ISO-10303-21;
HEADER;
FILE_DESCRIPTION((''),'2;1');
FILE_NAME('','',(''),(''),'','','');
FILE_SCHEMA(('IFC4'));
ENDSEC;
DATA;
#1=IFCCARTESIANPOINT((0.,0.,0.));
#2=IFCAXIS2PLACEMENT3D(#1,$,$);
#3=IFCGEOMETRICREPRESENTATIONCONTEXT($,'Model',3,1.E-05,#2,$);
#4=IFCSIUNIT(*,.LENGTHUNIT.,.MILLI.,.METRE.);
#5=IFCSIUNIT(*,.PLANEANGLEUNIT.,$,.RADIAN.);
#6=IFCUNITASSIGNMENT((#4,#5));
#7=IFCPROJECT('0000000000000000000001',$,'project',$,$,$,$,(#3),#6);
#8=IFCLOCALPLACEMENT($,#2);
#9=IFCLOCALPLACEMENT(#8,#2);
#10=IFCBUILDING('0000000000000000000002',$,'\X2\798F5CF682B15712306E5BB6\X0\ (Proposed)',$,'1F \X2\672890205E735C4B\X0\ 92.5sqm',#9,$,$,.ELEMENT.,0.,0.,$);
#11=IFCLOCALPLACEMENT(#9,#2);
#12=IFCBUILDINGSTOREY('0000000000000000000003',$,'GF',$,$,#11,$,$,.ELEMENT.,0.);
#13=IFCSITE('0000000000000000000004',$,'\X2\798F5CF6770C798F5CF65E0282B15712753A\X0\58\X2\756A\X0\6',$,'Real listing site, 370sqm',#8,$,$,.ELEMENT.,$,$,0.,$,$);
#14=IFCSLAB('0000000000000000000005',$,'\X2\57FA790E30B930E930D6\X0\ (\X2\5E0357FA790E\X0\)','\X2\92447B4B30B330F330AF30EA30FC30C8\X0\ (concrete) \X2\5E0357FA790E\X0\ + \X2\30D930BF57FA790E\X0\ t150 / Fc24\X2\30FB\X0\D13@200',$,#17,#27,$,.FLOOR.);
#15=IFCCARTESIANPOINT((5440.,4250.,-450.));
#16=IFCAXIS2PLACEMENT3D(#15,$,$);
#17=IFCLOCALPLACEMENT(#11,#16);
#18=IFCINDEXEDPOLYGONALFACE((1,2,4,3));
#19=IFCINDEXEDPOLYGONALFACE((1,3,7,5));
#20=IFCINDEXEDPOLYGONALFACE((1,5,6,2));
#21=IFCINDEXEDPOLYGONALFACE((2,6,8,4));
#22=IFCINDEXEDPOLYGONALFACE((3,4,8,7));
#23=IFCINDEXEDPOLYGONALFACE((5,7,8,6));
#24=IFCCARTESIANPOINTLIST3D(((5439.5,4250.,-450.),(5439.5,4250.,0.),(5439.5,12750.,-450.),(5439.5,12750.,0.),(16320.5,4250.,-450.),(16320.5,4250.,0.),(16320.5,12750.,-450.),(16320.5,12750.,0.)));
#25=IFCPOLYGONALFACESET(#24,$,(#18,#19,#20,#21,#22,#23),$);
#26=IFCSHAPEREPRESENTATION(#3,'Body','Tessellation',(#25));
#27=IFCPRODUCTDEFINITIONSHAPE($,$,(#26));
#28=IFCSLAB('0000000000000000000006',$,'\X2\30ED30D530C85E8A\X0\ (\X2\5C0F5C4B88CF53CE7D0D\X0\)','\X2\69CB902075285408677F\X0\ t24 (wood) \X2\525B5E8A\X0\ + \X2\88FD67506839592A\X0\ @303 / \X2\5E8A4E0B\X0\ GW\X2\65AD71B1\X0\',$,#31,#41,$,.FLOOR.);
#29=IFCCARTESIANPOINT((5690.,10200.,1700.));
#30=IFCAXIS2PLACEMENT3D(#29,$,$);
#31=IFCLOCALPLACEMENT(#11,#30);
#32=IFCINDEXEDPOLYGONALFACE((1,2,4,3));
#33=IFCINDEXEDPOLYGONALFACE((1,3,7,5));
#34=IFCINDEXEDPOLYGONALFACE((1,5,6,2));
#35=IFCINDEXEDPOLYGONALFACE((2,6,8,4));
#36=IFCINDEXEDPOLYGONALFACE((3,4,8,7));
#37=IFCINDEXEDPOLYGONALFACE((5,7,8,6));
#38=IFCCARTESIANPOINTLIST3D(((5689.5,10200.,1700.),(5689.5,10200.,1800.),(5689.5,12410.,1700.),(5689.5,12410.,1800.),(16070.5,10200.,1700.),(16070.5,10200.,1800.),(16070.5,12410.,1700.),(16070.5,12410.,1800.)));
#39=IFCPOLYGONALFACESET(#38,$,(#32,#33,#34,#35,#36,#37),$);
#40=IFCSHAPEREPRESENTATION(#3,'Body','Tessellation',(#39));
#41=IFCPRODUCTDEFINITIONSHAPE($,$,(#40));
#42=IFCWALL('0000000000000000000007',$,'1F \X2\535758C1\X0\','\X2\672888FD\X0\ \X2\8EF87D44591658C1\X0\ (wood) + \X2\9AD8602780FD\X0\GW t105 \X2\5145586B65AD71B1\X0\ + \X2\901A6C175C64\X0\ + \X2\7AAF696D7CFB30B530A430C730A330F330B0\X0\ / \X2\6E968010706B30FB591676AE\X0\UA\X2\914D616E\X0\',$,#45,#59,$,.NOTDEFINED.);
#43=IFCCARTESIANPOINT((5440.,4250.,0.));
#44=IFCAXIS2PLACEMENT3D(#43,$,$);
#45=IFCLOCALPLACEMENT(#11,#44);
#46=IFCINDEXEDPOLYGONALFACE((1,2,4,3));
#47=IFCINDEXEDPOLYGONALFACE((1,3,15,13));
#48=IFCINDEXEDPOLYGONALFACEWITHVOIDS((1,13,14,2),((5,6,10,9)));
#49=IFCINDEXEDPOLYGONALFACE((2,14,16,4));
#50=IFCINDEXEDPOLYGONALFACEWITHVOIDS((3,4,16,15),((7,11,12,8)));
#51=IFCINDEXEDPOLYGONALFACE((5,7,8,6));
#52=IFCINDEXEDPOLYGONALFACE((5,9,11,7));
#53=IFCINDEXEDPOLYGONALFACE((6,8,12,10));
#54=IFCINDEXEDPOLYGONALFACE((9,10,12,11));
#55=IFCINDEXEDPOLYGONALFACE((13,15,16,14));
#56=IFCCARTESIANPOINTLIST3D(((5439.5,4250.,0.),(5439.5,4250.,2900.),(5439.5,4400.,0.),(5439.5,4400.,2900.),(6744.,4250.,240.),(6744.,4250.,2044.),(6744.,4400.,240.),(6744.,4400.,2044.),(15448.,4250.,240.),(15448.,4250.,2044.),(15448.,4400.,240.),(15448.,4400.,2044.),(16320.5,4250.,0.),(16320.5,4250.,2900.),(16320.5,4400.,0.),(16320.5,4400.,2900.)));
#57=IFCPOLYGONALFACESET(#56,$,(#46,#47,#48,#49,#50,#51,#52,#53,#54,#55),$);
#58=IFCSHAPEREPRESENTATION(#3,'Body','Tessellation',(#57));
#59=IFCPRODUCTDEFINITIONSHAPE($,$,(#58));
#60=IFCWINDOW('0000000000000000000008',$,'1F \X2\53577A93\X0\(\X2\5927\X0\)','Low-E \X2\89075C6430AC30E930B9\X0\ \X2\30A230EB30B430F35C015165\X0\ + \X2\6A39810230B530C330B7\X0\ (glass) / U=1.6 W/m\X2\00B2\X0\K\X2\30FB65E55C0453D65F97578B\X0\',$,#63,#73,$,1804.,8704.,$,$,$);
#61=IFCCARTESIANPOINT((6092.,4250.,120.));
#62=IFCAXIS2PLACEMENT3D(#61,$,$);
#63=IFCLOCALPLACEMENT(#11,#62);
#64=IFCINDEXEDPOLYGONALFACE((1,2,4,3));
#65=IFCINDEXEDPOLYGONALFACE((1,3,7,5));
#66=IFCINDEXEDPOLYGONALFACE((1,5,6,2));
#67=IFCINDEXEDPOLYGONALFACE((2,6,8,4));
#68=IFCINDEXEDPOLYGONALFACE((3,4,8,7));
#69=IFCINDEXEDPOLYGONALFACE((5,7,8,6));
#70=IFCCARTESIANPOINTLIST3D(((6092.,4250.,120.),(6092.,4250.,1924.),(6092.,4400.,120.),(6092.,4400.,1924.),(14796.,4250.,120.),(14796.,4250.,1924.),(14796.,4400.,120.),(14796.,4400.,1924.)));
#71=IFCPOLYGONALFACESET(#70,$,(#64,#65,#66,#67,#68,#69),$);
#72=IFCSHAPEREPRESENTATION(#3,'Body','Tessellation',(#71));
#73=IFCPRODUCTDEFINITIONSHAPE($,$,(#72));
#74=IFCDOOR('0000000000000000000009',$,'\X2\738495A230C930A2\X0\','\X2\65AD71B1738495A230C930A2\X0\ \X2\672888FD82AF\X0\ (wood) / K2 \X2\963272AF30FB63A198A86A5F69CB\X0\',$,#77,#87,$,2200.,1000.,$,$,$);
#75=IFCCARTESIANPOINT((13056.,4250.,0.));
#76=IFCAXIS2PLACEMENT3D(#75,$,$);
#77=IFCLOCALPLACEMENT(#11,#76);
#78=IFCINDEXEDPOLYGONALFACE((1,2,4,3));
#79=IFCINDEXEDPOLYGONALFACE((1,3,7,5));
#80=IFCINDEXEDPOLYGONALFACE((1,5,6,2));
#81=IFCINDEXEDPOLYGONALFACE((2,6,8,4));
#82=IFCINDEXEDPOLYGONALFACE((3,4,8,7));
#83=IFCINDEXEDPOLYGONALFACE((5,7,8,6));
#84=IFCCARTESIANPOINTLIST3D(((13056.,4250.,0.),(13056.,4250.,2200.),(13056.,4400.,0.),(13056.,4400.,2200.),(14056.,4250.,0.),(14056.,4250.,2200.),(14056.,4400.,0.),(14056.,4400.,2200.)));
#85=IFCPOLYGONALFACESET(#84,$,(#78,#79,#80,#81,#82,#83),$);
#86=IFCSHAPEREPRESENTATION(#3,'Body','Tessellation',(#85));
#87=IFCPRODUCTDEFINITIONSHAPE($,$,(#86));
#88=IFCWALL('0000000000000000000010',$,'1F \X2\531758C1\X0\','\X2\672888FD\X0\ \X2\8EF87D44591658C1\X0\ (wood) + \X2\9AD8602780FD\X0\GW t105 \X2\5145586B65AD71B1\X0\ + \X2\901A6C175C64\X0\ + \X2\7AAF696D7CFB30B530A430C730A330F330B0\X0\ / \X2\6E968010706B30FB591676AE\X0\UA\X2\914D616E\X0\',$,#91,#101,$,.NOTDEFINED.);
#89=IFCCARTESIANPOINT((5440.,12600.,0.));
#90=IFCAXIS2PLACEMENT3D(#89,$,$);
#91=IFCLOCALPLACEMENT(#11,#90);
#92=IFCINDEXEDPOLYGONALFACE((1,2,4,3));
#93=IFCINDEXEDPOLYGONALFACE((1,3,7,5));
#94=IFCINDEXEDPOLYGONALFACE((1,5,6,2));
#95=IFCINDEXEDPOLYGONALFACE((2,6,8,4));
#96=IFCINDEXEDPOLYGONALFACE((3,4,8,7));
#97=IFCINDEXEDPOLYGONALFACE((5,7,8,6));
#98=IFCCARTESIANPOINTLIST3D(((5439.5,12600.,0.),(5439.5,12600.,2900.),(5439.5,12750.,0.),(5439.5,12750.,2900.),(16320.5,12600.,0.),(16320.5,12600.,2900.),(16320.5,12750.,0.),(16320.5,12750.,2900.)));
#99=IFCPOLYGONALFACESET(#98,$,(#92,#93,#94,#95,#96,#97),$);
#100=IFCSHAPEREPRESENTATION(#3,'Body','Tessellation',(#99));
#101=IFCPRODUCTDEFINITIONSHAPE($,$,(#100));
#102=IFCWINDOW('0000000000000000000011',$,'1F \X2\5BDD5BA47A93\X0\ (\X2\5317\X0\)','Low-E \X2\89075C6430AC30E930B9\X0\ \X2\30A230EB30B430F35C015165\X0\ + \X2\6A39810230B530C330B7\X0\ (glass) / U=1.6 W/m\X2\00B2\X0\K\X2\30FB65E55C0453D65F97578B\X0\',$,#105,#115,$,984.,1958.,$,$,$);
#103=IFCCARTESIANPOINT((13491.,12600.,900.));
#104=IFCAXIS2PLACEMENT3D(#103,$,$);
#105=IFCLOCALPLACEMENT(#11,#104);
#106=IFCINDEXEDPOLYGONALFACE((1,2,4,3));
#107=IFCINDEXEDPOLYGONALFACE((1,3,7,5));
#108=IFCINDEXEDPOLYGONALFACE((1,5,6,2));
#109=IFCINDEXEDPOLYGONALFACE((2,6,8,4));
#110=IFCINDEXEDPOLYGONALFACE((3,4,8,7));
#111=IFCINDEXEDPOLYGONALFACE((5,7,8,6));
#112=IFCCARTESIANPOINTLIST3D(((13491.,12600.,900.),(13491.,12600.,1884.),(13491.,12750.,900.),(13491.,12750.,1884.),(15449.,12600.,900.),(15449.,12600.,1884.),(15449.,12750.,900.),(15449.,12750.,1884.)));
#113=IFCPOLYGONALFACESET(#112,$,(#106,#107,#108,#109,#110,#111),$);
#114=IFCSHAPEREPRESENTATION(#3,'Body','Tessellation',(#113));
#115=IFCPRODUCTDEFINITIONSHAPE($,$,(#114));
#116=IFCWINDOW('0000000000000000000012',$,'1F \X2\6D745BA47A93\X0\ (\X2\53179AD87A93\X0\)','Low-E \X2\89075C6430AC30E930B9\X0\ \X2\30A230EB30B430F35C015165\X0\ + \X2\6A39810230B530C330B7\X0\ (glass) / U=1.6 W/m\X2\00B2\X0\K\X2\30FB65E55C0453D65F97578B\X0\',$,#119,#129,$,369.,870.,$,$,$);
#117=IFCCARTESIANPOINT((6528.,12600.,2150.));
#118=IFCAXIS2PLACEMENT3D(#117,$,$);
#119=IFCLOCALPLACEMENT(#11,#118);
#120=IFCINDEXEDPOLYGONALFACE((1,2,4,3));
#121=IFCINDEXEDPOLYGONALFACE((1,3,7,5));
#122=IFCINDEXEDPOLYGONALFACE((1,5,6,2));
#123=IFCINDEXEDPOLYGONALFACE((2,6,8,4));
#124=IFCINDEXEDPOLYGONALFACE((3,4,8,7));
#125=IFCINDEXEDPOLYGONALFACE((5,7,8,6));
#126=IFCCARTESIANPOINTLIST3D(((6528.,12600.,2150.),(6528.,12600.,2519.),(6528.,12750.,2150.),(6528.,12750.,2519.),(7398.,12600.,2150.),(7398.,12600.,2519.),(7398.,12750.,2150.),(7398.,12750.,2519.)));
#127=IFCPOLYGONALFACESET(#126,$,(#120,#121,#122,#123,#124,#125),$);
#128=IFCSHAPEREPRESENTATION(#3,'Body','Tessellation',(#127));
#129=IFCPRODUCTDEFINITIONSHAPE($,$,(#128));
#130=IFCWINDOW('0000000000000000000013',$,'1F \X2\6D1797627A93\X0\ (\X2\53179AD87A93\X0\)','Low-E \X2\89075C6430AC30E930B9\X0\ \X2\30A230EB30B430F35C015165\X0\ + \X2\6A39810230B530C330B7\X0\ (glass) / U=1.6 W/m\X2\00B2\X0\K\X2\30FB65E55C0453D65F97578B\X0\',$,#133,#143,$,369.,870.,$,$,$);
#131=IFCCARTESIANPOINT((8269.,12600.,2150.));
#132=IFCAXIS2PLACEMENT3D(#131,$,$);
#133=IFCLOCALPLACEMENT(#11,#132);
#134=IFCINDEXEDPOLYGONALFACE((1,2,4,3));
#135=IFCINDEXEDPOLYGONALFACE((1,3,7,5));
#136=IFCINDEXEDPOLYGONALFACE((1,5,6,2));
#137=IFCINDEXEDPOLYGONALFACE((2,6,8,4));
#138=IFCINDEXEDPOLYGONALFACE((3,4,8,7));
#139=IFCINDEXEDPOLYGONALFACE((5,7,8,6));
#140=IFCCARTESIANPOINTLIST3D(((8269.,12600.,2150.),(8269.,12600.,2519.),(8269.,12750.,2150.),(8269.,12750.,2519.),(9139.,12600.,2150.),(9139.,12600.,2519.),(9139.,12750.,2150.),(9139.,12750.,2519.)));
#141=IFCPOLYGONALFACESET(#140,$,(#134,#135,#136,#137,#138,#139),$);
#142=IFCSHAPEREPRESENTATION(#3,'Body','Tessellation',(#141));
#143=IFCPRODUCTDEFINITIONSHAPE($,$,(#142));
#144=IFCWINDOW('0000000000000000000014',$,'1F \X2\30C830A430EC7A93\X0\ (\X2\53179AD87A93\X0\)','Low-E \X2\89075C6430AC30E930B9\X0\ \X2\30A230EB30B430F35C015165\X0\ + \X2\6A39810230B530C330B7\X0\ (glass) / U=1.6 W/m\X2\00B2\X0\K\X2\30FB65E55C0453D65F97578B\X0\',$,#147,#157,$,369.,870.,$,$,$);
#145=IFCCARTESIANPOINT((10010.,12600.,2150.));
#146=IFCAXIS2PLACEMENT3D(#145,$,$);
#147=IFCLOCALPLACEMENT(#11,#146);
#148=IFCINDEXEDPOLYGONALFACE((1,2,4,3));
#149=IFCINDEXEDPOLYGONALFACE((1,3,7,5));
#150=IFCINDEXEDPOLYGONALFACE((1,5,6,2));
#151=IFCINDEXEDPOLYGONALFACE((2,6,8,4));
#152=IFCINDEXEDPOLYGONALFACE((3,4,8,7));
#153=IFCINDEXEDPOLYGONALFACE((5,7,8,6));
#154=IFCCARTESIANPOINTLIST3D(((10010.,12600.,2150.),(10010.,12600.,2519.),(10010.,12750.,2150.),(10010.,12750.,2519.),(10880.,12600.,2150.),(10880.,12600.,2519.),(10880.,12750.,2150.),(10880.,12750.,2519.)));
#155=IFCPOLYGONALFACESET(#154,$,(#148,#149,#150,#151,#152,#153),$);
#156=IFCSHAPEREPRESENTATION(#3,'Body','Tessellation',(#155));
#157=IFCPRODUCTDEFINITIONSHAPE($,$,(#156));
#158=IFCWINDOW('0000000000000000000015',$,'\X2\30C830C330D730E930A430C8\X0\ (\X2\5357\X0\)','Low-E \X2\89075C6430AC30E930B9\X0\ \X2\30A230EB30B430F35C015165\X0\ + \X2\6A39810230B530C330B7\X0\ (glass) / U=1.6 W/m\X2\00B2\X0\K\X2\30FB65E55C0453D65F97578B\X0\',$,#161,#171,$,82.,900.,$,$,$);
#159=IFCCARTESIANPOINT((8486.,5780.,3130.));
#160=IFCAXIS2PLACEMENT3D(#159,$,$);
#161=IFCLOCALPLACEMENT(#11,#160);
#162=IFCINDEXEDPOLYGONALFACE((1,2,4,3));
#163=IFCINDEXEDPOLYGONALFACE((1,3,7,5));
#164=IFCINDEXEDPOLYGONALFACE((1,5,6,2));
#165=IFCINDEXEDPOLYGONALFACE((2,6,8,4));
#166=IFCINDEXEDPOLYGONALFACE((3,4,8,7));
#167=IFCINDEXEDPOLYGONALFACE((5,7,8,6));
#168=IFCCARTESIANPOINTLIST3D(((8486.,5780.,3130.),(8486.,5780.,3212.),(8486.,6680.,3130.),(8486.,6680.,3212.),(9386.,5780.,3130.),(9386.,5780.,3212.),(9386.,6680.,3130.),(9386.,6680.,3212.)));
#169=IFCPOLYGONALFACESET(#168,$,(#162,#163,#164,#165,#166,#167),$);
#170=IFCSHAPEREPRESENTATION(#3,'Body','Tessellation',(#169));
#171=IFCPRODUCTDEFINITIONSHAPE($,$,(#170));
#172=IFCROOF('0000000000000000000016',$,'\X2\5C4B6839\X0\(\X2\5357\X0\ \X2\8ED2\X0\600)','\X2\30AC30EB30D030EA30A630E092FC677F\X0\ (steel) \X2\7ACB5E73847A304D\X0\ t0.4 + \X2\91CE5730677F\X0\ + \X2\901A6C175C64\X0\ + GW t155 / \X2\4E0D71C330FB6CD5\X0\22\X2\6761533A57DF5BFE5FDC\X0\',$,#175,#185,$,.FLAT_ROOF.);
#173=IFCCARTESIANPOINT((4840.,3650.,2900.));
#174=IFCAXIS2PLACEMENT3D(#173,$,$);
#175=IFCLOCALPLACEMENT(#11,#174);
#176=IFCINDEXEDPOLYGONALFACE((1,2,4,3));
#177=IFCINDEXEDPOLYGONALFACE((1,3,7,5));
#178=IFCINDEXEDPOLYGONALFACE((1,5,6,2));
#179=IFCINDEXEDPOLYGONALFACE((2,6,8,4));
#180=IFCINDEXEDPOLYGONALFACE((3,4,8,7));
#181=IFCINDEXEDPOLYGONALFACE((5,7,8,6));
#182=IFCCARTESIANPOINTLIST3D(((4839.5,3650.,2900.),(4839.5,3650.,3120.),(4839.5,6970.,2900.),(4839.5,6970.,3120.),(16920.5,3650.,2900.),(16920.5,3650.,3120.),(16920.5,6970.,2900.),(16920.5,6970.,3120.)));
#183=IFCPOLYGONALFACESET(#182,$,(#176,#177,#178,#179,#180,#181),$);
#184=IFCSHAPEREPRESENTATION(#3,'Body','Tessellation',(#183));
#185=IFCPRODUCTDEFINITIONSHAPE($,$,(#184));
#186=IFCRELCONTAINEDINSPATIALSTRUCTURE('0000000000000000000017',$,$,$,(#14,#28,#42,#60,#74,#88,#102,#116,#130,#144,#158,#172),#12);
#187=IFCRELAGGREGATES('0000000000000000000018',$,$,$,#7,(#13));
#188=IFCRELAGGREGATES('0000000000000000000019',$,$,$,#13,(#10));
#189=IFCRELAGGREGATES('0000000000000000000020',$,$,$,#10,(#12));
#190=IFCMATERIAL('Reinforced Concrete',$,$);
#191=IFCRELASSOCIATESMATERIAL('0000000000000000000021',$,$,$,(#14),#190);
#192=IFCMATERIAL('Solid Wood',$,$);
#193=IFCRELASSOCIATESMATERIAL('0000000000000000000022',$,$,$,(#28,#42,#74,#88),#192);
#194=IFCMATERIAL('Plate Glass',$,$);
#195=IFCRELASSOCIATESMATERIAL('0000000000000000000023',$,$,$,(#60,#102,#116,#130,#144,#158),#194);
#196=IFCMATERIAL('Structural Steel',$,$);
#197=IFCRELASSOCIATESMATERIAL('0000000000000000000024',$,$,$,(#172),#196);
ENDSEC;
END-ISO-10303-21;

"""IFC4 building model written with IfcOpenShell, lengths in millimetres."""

from ifc_helpers import new_model, si_unit, frame, frame_2d, origin, place, context, project, spatial, rectangle, extrude, material, element, fill, save


model = new_model("IFC4")

# Units and contexts
model_context = context("Model", 3, precision=1e-05, world=origin())
ifc_project = project(units=[si_unit("LENGTHUNIT", "METRE", prefix="MILLI"), si_unit("PLANEANGLEUNIT", "RADIAN")], contexts=[model_context])

# Site, building, storey
site_placement = place(None, origin())
site = spatial("IfcSite", under=ifc_project, at=site_placement, Name="福島県福島市花園町58番6", ObjectType="Real listing site, 370sqm", CompositionType="ELEMENT", RefElevation=0.0)
building_placement = place(site_placement, origin())
building = spatial("IfcBuilding", under=site, at=building_placement, Name="福島花園の家 (Proposed)", ObjectType="1F 木造平屋 92.5sqm", CompositionType="ELEMENT", ElevationOfRefHeight=0.0, ElevationOfTerrain=0.0)
storey_placement = place(building_placement, origin())
storey = spatial("IfcBuildingStorey", under=building, at=storey_placement, Name="GF", CompositionType="ELEMENT", Elevation=0.0)

# Slabs
ifc_material_1 = material(Name="Reinforced Concrete")
slab_1_placement = place(storey_placement, frame((5440.0, 4250.0, -450.0)))
element("IfcSlab", 1, at=slab_1_placement, inside=storey, material=ifc_material_1, Name="基礎スラブ (布基礎)", Description="鉄筋コンクリート (concrete) 布基礎 + ベタ基礎 t150 / Fc24・D13@200", PredefinedType="FLOOR", context=model_context, shape_type="SweptSolid", body=[
    extrude(rectangle(XDim=10881.0, YDim=8500.0, at=frame_2d((5440.0, 4250.0))), frame((5440.0, 4250.0, -450.0)), (0.0, 0.0, 1.0), 450.0),
])
ifc_material_2 = material(Name="Solid Wood")
slab_2_placement = place(storey_placement, frame((5690.0, 10200.0, 1700.0)))
element("IfcSlab", 2, at=slab_2_placement, inside=storey, material=ifc_material_2, Name="ロフト床 (小屋裏収納)", Description="構造用合板 t24 (wood) 剛床 + 製材根太 @303 / 床下 GW断熱", PredefinedType="FLOOR", context=model_context, shape_type="SweptSolid", body=[
    extrude(rectangle(XDim=10381.0, YDim=2210.0, at=frame_2d((5190.0, 1105.0))), frame((5690.0, 10200.0, 1700.0)), (0.0, 0.0, 1.0), 100.0),
])

# Wall, openings, window, door
wall_1_placement = place(storey_placement, frame((5440.0, 4250.0, 0.0)))
wall_1 = element("IfcWall", 3, at=wall_1_placement, inside=storey, material=ifc_material_2, Name="1F 南壁", Description="木製 軸組外壁 (wood) + 高性能GW t105 充填断熱 + 通気層 + 窯業系サイディング / 準耐火・外皮UA配慮", PredefinedType="NOTDEFINED", context=model_context, shape_type="SweptSolid", body=[
    extrude(rectangle(XDim=10881.0, YDim=150.0, at=frame_2d((5440.0, 75.0))), frame((5440.0, 4250.0, 0.0)), (0.0, 0.0, 1.0), 2900.0),
])
opening_1_placement = place(storey_placement, frame((6092.0, 4250.0, 120.0)))
opening_1 = element("IfcOpeningElement", 4, at=opening_1_placement, cuts=wall_1, PredefinedType="NOTDEFINED", context=model_context, shape_type="SweptSolid", body=[
    extrude(rectangle(XDim=8704.0, YDim=150.0, at=frame_2d((4352.0, 75.0))), frame((6092.0, 4250.0, 120.0)), (0.0, 0.0, 1.0), 1804.0),
])
opening_2_placement = place(storey_placement, frame((13056.0, 4250.0, 0.0)))
opening_2 = element("IfcOpeningElement", 5, at=opening_2_placement, cuts=wall_1, PredefinedType="NOTDEFINED", context=model_context, shape_type="SweptSolid", body=[
    extrude(rectangle(XDim=1000.0, YDim=150.0, at=frame_2d((500.0, 75.0))), frame((13056.0, 4250.0, 0.0)), (0.0, 0.0, 1.0), 2200.0),
])
ifc_material_3 = material(Name="Plate Glass")
window_1_placement = place(storey_placement, frame((6092.0, 4250.0, 120.0)))
window_1 = element("IfcWindow", 6, at=window_1_placement, inside=storey, material=ifc_material_3, Name="1F 南窓(大)", Description="Low-E 複層ガラス アルゴン封入 + 樹脂サッシ (glass) / U=1.6 W/m²K・日射取得型", OverallHeight=1804.0, OverallWidth=8704.0, context=model_context, shape_type="SweptSolid", body=[
    extrude(rectangle(XDim=8704.0, YDim=150.0, at=frame_2d((4352.0, 75.0))), frame((6092.0, 4250.0, 120.0)), (0.0, 0.0, 1.0), 1804.0),
])
fill(opening_1, window_1)
door_1_placement = place(storey_placement, frame((13056.0, 4250.0, 0.0)))
door_1 = element("IfcDoor", 7, at=door_1_placement, inside=storey, material=ifc_material_2, Name="玄関ドア", Description="断熱玄関ドア 木製芯 (wood) / K2 防犯・採風機構", OverallHeight=2200.0, OverallWidth=1000.0, context=model_context, shape_type="SweptSolid", body=[
    extrude(rectangle(XDim=1000.0, YDim=150.0, at=frame_2d((500.0, 75.0))), frame((13056.0, 4250.0, 0.0)), (0.0, 0.0, 1.0), 2200.0),
])
fill(opening_2, door_1)

# Wall, openings, windows
wall_2_placement = place(storey_placement, frame((5440.0, 12600.0, 0.0)))
wall_2 = element("IfcWall", 8, at=wall_2_placement, inside=storey, material=ifc_material_2, Name="1F 北壁", Description="木製 軸組外壁 (wood) + 高性能GW t105 充填断熱 + 通気層 + 窯業系サイディング / 準耐火・外皮UA配慮", PredefinedType="NOTDEFINED", context=model_context, shape_type="SweptSolid", body=[
    extrude(rectangle(XDim=10881.0, YDim=150.0, at=frame_2d((5440.0, 75.0))), frame((5440.0, 12600.0, 0.0)), (0.0, 0.0, 1.0), 2900.0),
])
opening_3_placement = place(storey_placement, frame((13491.0, 12600.0, 900.0)))
opening_3 = element("IfcOpeningElement", 9, at=opening_3_placement, cuts=wall_2, PredefinedType="NOTDEFINED", context=model_context, shape_type="SweptSolid", body=[
    extrude(rectangle(XDim=1958.0, YDim=150.0, at=frame_2d((979.0, 75.0))), frame((13491.0, 12600.0, 900.0)), (0.0, 0.0, 1.0), 984.0),
])
opening_4_placement = place(storey_placement, frame((6528.0, 12600.0, 2150.0)))
opening_4 = element("IfcOpeningElement", 10, at=opening_4_placement, cuts=wall_2, PredefinedType="NOTDEFINED", context=model_context, shape_type="SweptSolid", body=[
    extrude(rectangle(XDim=870.0, YDim=150.0, at=frame_2d((435.0, 75.0))), frame((6528.0, 12600.0, 2150.0)), (0.0, 0.0, 1.0), 369.0),
])
opening_5_placement = place(storey_placement, frame((8269.0, 12600.0, 2150.0)))
opening_5 = element("IfcOpeningElement", 11, at=opening_5_placement, cuts=wall_2, PredefinedType="NOTDEFINED", context=model_context, shape_type="SweptSolid", body=[
    extrude(rectangle(XDim=870.0, YDim=150.0, at=frame_2d((435.0, 75.0))), frame((8269.0, 12600.0, 2150.0)), (0.0, 0.0, 1.0), 369.0),
])
opening_6_placement = place(storey_placement, frame((10010.0, 12600.0, 2150.0)))
opening_6 = element("IfcOpeningElement", 12, at=opening_6_placement, cuts=wall_2, PredefinedType="NOTDEFINED", context=model_context, shape_type="SweptSolid", body=[
    extrude(rectangle(XDim=870.0, YDim=150.0, at=frame_2d((435.0, 75.0))), frame((10010.0, 12600.0, 2150.0)), (0.0, 0.0, 1.0), 369.0),
])
window_2_placement = place(storey_placement, frame((13491.0, 12600.0, 900.0)))
window_2 = element("IfcWindow", 13, at=window_2_placement, inside=storey, material=ifc_material_3, Name="1F 寝室窓 (北)", Description="Low-E 複層ガラス アルゴン封入 + 樹脂サッシ (glass) / U=1.6 W/m²K・日射取得型", OverallHeight=984.0, OverallWidth=1958.0, context=model_context, shape_type="SweptSolid", body=[
    extrude(rectangle(XDim=1958.0, YDim=150.0, at=frame_2d((979.0, 75.0))), frame((13491.0, 12600.0, 900.0)), (0.0, 0.0, 1.0), 984.0),
])
fill(opening_3, window_2)
window_3_placement = place(storey_placement, frame((6528.0, 12600.0, 2150.0)))
window_3 = element("IfcWindow", 14, at=window_3_placement, inside=storey, material=ifc_material_3, Name="1F 浴室窓 (北高窓)", Description="Low-E 複層ガラス アルゴン封入 + 樹脂サッシ (glass) / U=1.6 W/m²K・日射取得型", OverallHeight=369.0, OverallWidth=870.0, context=model_context, shape_type="SweptSolid", body=[
    extrude(rectangle(XDim=870.0, YDim=150.0, at=frame_2d((435.0, 75.0))), frame((6528.0, 12600.0, 2150.0)), (0.0, 0.0, 1.0), 369.0),
])
fill(opening_4, window_3)
window_4_placement = place(storey_placement, frame((8269.0, 12600.0, 2150.0)))
window_4 = element("IfcWindow", 15, at=window_4_placement, inside=storey, material=ifc_material_3, Name="1F 洗面窓 (北高窓)", Description="Low-E 複層ガラス アルゴン封入 + 樹脂サッシ (glass) / U=1.6 W/m²K・日射取得型", OverallHeight=369.0, OverallWidth=870.0, context=model_context, shape_type="SweptSolid", body=[
    extrude(rectangle(XDim=870.0, YDim=150.0, at=frame_2d((435.0, 75.0))), frame((8269.0, 12600.0, 2150.0)), (0.0, 0.0, 1.0), 369.0),
])
fill(opening_5, window_4)
window_5_placement = place(storey_placement, frame((10010.0, 12600.0, 2150.0)))
window_5 = element("IfcWindow", 16, at=window_5_placement, inside=storey, material=ifc_material_3, Name="1F トイレ窓 (北高窓)", Description="Low-E 複層ガラス アルゴン封入 + 樹脂サッシ (glass) / U=1.6 W/m²K・日射取得型", OverallHeight=369.0, OverallWidth=870.0, context=model_context, shape_type="SweptSolid", body=[
    extrude(rectangle(XDim=870.0, YDim=150.0, at=frame_2d((435.0, 75.0))), frame((10010.0, 12600.0, 2150.0)), (0.0, 0.0, 1.0), 369.0),
])
fill(opening_6, window_5)

# Window
window_6_placement = place(storey_placement, frame((8486.0, 5780.0, 3130.0)))
element("IfcWindow", 17, at=window_6_placement, inside=storey, material=ifc_material_3, Name="トップライト (南)", Description="Low-E 複層ガラス アルゴン封入 + 樹脂サッシ (glass) / U=1.6 W/m²K・日射取得型", OverallHeight=82.0, OverallWidth=900.0, context=model_context, shape_type="SweptSolid", body=[
    extrude(rectangle(XDim=900.0, YDim=900.0, at=frame_2d((450.0, 450.0))), frame((8486.0, 5780.0, 3130.0)), (0.0, 0.0, 1.0), 82.0),
])

# Roof
ifc_material_4 = material(Name="Structural Steel")
roof_1_placement = place(storey_placement, frame((4840.0, 3650.0, 2900.0)))
element("IfcRoof", 18, at=roof_1_placement, inside=storey, material=ifc_material_4, Name="屋根(南 軒600)", Description="ガルバリウム鋼板 (steel) 立平葺き t0.4 + 野地板 + 通気層 + GW t155 / 不燃・法22条区域対応", PredefinedType="FLAT_ROOF", context=model_context, shape_type="SweptSolid", body=[
    extrude(rectangle(XDim=12081.0, YDim=3320.0, at=frame_2d((6040.0, 1660.0))), frame((4840.0, 3650.0, 2900.0)), (0.0, 0.0, 1.0), 220.0),
])

save(model, "model.ifc")
